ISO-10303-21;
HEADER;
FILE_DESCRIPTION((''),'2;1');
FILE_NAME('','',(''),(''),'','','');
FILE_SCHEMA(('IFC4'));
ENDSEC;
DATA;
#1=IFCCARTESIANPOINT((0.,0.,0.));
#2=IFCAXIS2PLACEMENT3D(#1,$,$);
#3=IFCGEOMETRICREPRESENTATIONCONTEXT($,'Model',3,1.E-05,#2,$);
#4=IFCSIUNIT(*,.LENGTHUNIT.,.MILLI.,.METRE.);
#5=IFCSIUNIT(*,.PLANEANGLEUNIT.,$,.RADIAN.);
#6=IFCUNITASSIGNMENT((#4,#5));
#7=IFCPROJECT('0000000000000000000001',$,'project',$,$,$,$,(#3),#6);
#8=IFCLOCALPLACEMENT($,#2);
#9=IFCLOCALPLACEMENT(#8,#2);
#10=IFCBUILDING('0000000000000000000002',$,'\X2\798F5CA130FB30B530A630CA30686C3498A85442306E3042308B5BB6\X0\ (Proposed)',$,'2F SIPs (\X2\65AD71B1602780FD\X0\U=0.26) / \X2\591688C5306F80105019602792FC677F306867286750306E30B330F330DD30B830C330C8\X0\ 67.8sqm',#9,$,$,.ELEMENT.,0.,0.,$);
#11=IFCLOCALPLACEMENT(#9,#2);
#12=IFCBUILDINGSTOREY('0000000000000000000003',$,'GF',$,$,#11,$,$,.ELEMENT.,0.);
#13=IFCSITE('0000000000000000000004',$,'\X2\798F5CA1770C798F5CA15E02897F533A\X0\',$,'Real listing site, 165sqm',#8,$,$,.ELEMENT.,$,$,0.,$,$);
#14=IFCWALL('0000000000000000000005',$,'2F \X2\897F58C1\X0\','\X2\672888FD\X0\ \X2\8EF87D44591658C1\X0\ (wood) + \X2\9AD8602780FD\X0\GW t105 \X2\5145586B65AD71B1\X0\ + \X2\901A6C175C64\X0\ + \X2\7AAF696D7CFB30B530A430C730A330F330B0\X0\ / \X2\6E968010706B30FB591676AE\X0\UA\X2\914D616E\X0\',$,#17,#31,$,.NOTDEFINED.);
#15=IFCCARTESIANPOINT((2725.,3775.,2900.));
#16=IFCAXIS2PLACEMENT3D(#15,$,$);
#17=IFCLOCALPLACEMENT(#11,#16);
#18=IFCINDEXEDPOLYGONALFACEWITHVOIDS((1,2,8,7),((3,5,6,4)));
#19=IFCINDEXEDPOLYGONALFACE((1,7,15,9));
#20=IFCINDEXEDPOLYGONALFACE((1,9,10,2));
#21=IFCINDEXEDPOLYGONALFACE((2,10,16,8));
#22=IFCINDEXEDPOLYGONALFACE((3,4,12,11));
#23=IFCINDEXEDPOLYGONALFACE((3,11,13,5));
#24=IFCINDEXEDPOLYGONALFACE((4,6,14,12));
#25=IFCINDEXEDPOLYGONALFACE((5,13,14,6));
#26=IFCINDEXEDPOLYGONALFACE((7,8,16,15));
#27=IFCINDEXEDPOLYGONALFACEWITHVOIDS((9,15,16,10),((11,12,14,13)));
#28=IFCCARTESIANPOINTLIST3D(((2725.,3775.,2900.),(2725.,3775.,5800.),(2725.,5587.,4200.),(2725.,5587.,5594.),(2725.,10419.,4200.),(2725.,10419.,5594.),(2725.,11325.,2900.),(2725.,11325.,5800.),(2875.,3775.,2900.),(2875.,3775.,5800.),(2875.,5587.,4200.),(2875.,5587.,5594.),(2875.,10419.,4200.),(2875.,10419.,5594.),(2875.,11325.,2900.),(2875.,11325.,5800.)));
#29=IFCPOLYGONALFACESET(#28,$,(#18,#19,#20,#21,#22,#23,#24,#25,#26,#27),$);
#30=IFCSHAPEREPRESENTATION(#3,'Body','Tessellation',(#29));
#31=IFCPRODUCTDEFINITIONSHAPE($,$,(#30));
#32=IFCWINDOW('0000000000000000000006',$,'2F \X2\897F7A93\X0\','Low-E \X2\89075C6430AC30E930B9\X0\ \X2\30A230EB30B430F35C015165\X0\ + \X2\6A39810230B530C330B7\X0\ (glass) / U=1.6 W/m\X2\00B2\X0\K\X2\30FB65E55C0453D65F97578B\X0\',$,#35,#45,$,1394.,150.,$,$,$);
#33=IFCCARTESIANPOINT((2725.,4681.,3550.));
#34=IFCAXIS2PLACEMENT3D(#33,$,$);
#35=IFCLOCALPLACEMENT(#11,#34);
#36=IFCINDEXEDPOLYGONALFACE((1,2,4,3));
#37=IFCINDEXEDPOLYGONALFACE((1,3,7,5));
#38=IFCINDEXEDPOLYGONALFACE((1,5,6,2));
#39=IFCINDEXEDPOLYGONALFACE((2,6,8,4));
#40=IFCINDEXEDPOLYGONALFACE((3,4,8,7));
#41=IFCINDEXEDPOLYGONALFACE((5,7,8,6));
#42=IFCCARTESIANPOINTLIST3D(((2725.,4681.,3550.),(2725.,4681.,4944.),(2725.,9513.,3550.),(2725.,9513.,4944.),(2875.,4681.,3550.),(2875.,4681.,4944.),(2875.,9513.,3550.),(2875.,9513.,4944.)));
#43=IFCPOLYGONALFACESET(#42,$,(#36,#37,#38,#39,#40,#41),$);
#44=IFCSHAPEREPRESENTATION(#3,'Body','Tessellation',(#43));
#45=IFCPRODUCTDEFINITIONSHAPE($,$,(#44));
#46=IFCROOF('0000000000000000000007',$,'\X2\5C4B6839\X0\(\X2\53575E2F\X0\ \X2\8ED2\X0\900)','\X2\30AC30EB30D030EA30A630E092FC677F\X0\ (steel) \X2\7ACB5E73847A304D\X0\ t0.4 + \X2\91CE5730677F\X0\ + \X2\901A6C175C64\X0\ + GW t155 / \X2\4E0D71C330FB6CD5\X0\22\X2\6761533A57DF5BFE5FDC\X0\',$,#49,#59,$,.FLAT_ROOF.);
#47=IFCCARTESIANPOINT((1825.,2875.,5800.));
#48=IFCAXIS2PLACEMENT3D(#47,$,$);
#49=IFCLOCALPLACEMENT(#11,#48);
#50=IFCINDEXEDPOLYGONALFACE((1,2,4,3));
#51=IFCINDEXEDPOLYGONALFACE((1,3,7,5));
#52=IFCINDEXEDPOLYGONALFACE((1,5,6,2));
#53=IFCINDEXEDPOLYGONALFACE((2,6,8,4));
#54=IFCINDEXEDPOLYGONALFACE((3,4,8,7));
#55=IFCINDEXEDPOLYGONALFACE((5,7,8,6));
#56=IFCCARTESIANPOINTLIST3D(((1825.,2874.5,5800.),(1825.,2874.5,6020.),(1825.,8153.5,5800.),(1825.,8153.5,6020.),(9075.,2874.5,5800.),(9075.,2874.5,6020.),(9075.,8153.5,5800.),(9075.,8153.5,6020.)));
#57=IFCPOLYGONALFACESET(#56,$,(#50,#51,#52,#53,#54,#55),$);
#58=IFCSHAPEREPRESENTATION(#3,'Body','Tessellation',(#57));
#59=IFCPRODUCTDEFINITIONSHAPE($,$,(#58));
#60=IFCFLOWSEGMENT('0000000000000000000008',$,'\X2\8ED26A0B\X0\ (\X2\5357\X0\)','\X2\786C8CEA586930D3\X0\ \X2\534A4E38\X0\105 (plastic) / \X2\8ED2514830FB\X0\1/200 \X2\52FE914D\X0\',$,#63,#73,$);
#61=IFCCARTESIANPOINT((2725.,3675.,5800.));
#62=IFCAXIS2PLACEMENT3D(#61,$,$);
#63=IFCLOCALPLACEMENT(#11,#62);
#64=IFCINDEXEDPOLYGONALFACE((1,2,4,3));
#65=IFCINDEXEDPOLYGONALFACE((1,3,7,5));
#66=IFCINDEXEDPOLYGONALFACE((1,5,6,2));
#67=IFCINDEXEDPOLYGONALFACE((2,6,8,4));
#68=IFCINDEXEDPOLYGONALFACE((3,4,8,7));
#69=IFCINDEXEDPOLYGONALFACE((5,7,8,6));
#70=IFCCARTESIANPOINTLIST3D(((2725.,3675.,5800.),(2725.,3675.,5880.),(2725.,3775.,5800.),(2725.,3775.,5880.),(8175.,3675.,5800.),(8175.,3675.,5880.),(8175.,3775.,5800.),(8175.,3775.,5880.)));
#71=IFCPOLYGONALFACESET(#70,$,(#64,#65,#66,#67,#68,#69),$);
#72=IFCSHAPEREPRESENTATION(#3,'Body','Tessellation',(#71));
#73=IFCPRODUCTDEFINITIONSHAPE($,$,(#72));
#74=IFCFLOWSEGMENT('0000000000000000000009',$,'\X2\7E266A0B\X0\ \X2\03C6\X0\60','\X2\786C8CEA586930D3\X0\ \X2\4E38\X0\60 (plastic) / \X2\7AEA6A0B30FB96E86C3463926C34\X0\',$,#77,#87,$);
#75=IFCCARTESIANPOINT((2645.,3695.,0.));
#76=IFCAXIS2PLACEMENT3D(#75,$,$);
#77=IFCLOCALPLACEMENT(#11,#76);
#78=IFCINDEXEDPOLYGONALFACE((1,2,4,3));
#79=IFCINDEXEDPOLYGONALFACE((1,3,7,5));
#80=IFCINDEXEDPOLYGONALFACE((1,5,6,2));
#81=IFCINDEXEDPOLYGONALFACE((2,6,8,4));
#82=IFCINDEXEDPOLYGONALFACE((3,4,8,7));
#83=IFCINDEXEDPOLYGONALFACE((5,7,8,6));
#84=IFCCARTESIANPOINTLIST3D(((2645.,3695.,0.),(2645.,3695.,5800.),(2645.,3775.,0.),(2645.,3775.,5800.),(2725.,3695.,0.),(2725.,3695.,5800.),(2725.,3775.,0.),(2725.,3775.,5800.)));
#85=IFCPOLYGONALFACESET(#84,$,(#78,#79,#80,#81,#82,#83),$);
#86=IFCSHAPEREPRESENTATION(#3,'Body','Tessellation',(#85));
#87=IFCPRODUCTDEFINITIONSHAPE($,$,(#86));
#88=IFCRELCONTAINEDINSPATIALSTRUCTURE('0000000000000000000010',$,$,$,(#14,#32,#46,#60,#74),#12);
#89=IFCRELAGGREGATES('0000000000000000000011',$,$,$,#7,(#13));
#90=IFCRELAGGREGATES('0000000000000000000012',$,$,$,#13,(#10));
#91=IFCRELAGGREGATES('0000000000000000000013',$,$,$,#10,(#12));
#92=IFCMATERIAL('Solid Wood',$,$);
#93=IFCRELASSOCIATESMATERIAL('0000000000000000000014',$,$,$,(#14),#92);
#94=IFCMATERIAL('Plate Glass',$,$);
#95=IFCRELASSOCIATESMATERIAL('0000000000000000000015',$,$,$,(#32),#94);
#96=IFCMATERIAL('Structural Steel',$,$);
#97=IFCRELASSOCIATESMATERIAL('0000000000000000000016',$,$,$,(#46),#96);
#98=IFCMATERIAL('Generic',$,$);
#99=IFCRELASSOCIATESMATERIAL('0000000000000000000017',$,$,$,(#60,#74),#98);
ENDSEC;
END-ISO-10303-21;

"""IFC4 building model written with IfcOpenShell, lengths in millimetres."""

from ifc_helpers import new_model, si_unit, frame, frame_2d, origin, place, context, project, spatial, rectangle, extrude, material, element, fill, save


model = new_model("IFC4")

# Units and contexts
model_context = context("Model", 3, precision=1e-05, world=origin())
ifc_project = project(units=[si_unit("LENGTHUNIT", "METRE", prefix="MILLI"), si_unit("PLANEANGLEUNIT", "RADIAN")], contexts=[model_context])

# Site, building, storey
site_placement = place(None, origin())
site = spatial("IfcSite", under=ifc_project, at=site_placement, Name="福岡県福岡市西区", ObjectType="Real listing site, 165sqm", CompositionType="ELEMENT", RefElevation=0.0)
building_placement = place(site_placement, origin())
building = spatial("IfcBuilding", under=site, at=building_placement, Name="福岡・サウナと水風呂のある家 (Proposed)", ObjectType="2F SIPs (断熱性能U=0.26) / 外装は耐候性鋼板と木材のコンポジット 67.8sqm", CompositionType="ELEMENT", ElevationOfRefHeight=0.0, ElevationOfTerrain=0.0)
storey_placement = place(building_placement, origin())
storey = spatial("IfcBuildingStorey", under=building, at=storey_placement, Name="GF", CompositionType="ELEMENT", Elevation=0.0)

# Shared definitions
ifc_material_1 = material(Name="Solid Wood")

# Shared definitions
ifc_material_2 = material(Name="Plate Glass")

# Wall, opening, window
wall_1_placement = place(storey_placement, frame((2725.0, 3775.0, 2900.0)))
wall_1 = element("IfcWall", 1, at=wall_1_placement, inside=storey, material=ifc_material_1, Name="2F 西壁", Description="木製 軸組外壁 (wood) + 高性能GW t105 充填断熱 + 通気層 + 窯業系サイディング / 準耐火・外皮UA配慮", PredefinedType="NOTDEFINED", context=model_context, shape_type="SweptSolid", body=[
    extrude(rectangle(XDim=150.0, YDim=7550.0, at=frame_2d((75.0, 3775.0))), frame((2725.0, 3775.0, 2900.0)), (0.0, 0.0, 1.0), 2900.0),
])
opening_1_placement = place(storey_placement, frame((2725.0, 4681.0, 3550.0)))
opening_1 = element("IfcOpeningElement", 2, at=opening_1_placement, cuts=wall_1, PredefinedType="NOTDEFINED", context=model_context, shape_type="SweptSolid", body=[
    extrude(rectangle(XDim=150.0, YDim=4832.0, at=frame_2d((75.0, 2416.0))), frame((2725.0, 4681.0, 3550.0)), (0.0, 0.0, 1.0), 1394.0),
])
window_1_placement = place(storey_placement, frame((2725.0, 4681.0, 3550.0)))
window_1 = element("IfcWindow", 3, at=window_1_placement, inside=storey, material=ifc_material_2, Name="2F 西窓", Description="Low-E 複層ガラス アルゴン封入 + 樹脂サッシ (glass) / U=1.6 W/m²K・日射取得型", OverallHeight=1394.0, OverallWidth=150.0, context=model_context, shape_type="SweptSolid", body=[
    extrude(rectangle(XDim=150.0, YDim=4832.0, at=frame_2d((75.0, 2416.0))), frame((2725.0, 4681.0, 3550.0)), (0.0, 0.0, 1.0), 1394.0),
])
fill(opening_1, window_1)

# Roof
ifc_material_3 = material(Name="Structural Steel")
for number, where, name in (
    (4, (1825.0, 2875.0, 5800.0), "屋根(南帯 軒900)"),
):
    element("IfcRoof", number, at=place(storey_placement, frame(where)), inside=storey, material=ifc_material_3, Name=name, Description="ガルバリウム鋼板 (steel) 立平葺き t0.4 + 野地板 + 通気層 + GW t155 / 不燃・法22条区域対応", PredefinedType="FLAT_ROOF", context=model_context, shape_type="SweptSolid", body=[
        extrude(rectangle(XDim=7250.0, YDim=5279.0, at=frame_2d((3625.0, 2639.0))), frame((1825.0, 2875.0, 5800.0)), (0.0, 0.0, 1.0), 220.0),
    ])

# Flow segments
ifc_material_4 = material(Name="Generic")
flow_segment_1_placement = place(storey_placement, frame((2725.0, 3675.0, 5800.0)))
element("IfcFlowSegment", 5, at=flow_segment_1_placement, inside=storey, material=ifc_material_4, Name="軒樋 (南)", Description="硬質塩ビ 半丸105 (plastic) / 軒先・1/200 勾配", context=model_context, shape_type="SweptSolid", body=[
    extrude(rectangle(XDim=5450.0, YDim=100.0, at=frame_2d((2725.0, 50.0))), frame((2725.0, 3675.0, 5800.0)), (0.0, 0.0, 1.0), 80.0),
])
flow_segment_2_placement = place(storey_placement, frame((2645.0, 3695.0, 0.0)))
element("IfcFlowSegment", 6, at=flow_segment_2_placement, inside=storey, material=ifc_material_4, Name="縦樋 φ60", Description="硬質塩ビ 丸60 (plastic) / 竪樋・雨水排水", context=model_context, shape_type="SweptSolid", body=[
    extrude(rectangle(XDim=80.0, YDim=80.0, at=frame_2d((40.0, 40.0))), frame((2645.0, 3695.0, 0.0)), (0.0, 0.0, 1.0), 5800.0),
])

save(model, "model.ifc")
